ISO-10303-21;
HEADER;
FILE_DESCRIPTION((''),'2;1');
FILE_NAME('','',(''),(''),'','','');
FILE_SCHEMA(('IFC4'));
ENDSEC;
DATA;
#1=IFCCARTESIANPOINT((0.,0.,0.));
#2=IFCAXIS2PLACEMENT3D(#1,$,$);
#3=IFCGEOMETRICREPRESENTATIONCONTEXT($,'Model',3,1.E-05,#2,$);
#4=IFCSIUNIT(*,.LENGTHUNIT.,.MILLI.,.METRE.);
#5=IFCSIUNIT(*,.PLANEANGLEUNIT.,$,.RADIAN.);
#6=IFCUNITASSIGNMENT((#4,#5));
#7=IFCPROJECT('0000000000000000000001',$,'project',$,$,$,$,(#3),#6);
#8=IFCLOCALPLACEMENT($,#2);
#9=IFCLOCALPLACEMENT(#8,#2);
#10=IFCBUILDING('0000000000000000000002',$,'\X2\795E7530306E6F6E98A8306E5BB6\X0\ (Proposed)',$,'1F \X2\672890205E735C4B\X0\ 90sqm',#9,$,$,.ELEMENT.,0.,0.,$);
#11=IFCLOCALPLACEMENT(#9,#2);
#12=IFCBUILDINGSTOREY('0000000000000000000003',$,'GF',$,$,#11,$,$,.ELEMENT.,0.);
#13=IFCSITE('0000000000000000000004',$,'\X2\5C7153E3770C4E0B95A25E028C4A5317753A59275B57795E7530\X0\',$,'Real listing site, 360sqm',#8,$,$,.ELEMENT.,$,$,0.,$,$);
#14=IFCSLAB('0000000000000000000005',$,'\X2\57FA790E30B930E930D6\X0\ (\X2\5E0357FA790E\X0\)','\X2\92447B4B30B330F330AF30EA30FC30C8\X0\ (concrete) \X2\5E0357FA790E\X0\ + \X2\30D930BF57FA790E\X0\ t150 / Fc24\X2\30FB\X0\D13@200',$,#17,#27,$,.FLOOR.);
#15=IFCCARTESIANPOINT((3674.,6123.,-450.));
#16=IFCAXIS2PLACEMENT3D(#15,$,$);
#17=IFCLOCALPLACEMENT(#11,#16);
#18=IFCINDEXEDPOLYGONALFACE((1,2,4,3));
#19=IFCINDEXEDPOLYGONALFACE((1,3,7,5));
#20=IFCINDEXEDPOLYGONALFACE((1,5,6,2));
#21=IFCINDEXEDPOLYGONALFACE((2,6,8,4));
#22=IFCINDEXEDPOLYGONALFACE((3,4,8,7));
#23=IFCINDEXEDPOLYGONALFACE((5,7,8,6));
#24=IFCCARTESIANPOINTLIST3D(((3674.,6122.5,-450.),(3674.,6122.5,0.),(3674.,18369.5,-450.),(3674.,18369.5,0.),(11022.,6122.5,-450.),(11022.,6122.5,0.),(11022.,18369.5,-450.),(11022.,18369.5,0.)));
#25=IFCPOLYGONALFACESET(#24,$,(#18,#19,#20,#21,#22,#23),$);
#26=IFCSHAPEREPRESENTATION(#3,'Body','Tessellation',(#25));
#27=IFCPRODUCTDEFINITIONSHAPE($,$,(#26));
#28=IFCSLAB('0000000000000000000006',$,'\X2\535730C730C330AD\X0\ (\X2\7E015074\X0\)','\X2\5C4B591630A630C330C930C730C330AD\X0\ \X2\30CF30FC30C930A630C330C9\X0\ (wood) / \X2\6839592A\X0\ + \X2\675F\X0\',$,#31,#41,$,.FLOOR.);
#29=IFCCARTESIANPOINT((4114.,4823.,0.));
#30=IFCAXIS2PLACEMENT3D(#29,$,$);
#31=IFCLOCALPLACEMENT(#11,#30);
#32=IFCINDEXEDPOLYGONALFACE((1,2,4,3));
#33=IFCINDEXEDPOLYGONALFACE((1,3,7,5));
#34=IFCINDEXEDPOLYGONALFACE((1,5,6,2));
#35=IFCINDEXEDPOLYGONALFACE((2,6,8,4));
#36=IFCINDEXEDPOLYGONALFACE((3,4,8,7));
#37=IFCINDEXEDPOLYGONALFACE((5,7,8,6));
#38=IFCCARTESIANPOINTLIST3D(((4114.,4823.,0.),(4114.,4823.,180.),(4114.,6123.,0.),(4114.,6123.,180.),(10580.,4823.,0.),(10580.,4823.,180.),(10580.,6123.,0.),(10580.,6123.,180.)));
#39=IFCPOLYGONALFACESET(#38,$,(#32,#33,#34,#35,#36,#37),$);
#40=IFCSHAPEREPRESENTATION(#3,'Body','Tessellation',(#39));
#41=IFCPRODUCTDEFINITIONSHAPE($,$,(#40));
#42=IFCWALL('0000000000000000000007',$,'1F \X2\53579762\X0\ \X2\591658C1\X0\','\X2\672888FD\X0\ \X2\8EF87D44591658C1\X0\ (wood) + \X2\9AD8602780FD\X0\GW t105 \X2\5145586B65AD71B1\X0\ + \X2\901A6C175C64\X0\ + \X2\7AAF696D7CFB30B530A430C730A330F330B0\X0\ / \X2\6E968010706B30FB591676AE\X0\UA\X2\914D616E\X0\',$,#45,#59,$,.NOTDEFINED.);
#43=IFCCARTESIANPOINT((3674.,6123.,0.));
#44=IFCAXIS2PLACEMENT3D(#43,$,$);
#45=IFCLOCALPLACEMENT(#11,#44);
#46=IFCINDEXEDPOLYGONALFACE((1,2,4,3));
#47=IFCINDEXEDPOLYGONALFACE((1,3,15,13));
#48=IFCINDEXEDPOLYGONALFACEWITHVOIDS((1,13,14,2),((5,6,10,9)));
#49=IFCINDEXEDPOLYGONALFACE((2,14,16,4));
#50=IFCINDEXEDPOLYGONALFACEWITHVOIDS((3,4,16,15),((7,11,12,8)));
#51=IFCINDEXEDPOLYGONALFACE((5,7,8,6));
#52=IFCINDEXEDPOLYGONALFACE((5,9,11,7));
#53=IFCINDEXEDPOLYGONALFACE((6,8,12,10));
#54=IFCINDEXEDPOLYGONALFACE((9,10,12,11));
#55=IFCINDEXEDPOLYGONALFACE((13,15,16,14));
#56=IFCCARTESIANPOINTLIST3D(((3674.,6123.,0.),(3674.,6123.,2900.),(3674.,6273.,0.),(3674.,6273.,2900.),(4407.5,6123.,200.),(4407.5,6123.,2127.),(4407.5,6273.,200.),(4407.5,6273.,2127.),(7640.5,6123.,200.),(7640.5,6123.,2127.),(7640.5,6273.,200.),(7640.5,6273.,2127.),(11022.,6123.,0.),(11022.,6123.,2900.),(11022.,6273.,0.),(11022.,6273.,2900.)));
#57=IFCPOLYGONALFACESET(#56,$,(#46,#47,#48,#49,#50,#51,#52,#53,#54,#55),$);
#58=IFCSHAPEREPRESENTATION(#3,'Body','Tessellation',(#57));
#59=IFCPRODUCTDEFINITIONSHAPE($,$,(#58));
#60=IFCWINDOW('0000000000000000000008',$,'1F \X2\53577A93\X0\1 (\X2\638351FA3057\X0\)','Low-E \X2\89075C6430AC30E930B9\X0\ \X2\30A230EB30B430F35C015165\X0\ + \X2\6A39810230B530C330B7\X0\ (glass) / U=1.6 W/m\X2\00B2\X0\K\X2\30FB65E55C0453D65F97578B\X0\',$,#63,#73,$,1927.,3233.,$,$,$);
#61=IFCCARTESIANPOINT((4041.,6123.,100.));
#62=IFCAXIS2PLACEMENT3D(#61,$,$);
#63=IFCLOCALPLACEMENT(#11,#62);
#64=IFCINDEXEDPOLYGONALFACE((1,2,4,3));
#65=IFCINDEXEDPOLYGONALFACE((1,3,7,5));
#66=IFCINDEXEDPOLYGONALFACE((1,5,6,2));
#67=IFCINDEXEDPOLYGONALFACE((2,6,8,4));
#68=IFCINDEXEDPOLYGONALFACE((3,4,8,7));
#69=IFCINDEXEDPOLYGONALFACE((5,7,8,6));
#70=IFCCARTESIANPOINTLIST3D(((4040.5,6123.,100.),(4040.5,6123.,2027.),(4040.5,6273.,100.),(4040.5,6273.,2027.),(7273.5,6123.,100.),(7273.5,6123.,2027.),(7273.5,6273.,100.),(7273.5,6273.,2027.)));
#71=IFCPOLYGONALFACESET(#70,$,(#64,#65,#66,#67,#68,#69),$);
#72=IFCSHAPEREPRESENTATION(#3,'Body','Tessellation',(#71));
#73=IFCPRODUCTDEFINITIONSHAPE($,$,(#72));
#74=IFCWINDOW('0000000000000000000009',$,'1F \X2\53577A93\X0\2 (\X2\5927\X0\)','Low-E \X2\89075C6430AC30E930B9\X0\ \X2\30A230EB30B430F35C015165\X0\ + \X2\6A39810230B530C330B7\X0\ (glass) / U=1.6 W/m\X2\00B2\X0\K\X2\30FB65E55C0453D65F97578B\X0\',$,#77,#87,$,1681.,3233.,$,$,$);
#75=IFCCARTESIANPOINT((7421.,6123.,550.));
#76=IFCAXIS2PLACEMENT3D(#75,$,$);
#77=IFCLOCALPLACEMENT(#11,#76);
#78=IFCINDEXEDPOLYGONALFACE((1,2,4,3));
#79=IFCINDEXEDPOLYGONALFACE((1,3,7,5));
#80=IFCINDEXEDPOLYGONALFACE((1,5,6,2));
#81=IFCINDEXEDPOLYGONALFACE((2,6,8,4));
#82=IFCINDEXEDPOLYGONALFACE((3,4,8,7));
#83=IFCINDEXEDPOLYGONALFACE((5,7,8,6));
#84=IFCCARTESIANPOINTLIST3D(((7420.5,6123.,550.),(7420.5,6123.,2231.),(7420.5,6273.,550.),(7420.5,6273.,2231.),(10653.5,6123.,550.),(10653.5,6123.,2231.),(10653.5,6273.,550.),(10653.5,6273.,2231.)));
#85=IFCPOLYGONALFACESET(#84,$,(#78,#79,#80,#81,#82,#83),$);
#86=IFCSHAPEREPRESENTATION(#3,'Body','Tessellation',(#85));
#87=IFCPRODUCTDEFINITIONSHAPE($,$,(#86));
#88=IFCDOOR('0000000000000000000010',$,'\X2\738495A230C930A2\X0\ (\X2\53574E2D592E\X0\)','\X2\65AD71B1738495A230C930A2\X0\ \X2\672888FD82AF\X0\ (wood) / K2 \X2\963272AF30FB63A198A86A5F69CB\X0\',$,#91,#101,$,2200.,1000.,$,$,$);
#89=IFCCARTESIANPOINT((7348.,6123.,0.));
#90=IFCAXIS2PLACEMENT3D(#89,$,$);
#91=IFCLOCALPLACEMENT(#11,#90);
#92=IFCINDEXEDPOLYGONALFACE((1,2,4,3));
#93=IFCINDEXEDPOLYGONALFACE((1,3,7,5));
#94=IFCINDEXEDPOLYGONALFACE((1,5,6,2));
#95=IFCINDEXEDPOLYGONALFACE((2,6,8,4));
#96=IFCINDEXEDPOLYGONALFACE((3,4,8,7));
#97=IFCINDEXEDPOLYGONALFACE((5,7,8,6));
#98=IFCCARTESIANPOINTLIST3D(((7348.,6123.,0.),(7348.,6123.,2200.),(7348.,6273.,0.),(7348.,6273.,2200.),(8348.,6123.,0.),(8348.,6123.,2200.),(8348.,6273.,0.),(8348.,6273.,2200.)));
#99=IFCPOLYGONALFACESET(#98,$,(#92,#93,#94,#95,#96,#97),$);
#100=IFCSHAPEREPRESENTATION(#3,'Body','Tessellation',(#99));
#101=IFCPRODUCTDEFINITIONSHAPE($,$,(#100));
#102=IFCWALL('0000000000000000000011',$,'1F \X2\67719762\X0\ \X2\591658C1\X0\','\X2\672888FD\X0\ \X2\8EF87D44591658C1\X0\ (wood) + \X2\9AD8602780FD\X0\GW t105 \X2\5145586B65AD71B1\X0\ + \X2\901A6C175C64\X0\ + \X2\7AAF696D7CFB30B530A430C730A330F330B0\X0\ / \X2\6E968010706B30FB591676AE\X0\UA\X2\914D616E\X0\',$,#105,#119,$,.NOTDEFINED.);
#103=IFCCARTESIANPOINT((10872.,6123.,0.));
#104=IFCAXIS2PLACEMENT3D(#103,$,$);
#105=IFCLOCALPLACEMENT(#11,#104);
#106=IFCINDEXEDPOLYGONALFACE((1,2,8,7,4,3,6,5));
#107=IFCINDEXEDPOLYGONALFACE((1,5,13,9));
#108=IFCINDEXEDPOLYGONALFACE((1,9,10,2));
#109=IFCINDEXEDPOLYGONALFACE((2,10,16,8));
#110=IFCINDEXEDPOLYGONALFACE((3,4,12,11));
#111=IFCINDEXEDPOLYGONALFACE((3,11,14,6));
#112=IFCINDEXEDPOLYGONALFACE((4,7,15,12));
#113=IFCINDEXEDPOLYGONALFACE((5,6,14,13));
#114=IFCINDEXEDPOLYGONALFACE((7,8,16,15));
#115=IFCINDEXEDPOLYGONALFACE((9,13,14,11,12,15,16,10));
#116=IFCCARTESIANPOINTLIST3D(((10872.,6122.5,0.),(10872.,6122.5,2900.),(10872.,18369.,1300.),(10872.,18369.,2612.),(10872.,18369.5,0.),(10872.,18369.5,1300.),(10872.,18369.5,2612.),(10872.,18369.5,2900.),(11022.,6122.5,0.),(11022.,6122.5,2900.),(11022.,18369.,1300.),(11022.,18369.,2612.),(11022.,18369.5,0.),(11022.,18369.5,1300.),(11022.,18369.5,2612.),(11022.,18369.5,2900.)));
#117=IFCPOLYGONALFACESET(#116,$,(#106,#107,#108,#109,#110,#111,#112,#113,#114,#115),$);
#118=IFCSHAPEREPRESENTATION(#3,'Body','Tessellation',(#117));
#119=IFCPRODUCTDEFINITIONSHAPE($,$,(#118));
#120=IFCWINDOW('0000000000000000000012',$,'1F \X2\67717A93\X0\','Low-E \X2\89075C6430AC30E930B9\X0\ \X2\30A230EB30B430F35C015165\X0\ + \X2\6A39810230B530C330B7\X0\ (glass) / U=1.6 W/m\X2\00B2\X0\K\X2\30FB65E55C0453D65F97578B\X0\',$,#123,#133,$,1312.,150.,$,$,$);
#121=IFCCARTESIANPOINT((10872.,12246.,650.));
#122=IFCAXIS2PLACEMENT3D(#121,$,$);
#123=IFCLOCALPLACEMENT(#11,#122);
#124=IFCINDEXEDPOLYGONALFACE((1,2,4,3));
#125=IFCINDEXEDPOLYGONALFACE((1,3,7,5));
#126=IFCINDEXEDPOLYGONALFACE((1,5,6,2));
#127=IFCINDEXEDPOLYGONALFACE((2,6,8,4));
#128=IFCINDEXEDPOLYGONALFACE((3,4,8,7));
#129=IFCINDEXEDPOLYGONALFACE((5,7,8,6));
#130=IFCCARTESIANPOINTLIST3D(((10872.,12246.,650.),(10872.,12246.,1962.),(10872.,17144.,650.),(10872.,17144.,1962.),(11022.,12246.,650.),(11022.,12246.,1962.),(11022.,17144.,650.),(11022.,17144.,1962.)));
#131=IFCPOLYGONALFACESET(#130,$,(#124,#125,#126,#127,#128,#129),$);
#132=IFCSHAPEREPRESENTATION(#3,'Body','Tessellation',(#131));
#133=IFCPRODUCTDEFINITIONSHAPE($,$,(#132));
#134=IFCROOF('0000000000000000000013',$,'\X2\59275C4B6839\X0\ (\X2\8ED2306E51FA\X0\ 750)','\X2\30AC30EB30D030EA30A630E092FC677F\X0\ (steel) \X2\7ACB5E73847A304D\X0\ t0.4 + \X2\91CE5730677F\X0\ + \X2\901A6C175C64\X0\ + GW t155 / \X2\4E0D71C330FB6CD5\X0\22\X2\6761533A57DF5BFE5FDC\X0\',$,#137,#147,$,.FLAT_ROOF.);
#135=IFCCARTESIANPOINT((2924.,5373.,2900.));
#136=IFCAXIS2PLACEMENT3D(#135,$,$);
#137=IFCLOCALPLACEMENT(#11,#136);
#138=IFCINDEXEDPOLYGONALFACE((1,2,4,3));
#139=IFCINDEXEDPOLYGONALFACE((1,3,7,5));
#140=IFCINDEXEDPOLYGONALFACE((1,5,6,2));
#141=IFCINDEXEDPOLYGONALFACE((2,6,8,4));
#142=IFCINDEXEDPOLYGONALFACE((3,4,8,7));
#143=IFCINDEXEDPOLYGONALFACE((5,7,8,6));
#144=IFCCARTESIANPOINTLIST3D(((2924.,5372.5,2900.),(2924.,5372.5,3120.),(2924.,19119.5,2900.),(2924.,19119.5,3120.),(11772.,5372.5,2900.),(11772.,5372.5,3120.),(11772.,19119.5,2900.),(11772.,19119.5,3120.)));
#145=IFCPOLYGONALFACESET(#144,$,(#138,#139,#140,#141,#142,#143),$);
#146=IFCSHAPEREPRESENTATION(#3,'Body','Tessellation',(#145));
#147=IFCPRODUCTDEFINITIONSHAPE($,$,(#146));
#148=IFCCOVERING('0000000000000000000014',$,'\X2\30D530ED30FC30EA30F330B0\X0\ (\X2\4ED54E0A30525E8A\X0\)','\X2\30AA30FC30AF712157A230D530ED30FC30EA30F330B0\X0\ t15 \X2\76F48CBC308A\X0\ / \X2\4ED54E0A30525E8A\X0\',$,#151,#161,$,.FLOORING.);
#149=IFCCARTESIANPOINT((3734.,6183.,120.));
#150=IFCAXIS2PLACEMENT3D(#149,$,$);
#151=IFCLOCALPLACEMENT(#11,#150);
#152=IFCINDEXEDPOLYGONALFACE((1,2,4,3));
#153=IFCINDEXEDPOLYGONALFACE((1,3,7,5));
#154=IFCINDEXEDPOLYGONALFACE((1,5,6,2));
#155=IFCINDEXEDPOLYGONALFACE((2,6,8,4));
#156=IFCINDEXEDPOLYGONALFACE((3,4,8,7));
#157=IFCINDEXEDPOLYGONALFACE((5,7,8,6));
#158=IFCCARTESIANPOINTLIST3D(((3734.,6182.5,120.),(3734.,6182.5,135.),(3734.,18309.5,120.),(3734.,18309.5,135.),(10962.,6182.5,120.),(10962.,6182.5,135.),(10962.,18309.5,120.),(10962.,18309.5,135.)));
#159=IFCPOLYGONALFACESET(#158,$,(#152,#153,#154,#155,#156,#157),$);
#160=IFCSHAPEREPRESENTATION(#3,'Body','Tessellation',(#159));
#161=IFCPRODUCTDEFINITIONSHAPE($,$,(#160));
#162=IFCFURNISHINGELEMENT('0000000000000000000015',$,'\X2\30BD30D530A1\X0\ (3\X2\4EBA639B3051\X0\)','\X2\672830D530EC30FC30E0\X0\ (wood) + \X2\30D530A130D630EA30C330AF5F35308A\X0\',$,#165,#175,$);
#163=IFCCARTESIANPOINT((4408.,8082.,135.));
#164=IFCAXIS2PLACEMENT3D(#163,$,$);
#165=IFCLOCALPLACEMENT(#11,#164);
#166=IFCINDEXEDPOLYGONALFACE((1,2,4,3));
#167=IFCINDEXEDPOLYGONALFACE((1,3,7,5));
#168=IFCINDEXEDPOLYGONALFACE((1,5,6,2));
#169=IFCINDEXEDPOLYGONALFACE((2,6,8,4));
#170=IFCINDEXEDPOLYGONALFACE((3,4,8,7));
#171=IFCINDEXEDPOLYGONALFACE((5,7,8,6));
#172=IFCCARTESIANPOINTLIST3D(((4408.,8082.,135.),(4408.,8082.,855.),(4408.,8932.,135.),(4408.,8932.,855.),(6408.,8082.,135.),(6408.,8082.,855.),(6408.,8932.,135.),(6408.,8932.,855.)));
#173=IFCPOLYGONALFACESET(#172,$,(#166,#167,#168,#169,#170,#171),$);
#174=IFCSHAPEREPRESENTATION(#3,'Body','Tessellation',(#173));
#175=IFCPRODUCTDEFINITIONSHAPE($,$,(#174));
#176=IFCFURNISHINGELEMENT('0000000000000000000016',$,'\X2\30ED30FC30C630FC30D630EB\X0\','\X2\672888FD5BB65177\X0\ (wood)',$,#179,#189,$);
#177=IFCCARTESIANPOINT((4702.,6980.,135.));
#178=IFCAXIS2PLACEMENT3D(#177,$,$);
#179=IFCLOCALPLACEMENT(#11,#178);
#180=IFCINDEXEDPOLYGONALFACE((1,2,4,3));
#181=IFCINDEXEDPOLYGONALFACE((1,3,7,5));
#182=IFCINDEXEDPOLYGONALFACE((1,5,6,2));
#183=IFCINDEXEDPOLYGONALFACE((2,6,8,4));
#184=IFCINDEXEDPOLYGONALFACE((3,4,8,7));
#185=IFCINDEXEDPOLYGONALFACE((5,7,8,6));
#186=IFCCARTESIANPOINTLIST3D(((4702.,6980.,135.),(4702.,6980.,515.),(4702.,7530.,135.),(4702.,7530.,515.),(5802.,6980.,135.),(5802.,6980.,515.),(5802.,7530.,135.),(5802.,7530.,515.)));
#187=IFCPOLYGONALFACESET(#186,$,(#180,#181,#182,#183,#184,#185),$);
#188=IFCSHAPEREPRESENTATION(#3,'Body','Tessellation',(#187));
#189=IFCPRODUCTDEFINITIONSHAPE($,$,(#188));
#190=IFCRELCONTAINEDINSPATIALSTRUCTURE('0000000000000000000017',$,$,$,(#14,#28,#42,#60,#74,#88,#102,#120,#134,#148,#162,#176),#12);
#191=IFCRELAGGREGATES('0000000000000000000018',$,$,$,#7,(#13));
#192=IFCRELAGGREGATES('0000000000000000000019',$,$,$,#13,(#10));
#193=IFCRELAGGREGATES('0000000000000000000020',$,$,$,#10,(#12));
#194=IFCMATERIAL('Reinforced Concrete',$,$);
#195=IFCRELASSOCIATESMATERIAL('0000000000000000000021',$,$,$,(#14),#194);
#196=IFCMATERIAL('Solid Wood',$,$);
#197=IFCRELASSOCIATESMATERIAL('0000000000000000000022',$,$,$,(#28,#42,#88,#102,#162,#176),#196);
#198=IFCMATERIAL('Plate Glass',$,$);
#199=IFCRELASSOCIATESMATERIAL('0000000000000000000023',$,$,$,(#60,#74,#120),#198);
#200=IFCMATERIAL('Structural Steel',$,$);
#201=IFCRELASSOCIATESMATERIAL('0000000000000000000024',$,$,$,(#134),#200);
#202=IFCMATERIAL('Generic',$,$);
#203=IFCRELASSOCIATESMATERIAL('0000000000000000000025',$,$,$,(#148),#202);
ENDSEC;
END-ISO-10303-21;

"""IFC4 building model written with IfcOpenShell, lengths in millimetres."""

from ifc_helpers import new_model, si_unit, frame, frame_2d, origin, place, context, project, spatial, rectangle, extrude, material, element, fill, save


model = new_model("IFC4")

# Units and contexts
model_context = context("Model", 3, precision=1e-05, world=origin())
ifc_project = project(units=[si_unit("LENGTHUNIT", "METRE", prefix="MILLI"), si_unit("PLANEANGLEUNIT", "RADIAN")], contexts=[model_context])

# Site, building, storey
site_placement = place(None, origin())
site = spatial("IfcSite", under=ifc_project, at=site_placement, Name="山口県下関市豊北町大字神田", ObjectType="Real listing site, 360sqm", CompositionType="ELEMENT", RefElevation=0.0)
building_placement = place(site_placement, origin())
building = spatial("IfcBuilding", under=site, at=building_placement, Name="神田の潮風の家 (Proposed)", ObjectType="1F 木造平屋 90sqm", CompositionType="ELEMENT", ElevationOfRefHeight=0.0, ElevationOfTerrain=0.0)
storey_placement = place(building_placement, origin())
storey = spatial("IfcBuildingStorey", under=building, at=storey_placement, Name="GF", CompositionType="ELEMENT", Elevation=0.0)

# Slabs
ifc_material_1 = material(Name="Reinforced Concrete")
slab_1_placement = place(storey_placement, frame((3674.0, 6123.0, -450.0)))
element("IfcSlab", 1, at=slab_1_placement, inside=storey, material=ifc_material_1, Name="基礎スラブ (布基礎)", Description="鉄筋コンクリート (concrete) 布基礎 + ベタ基礎 t150 / Fc24・D13@200", PredefinedType="FLOOR", context=model_context, shape_type="SweptSolid", body=[
    extrude(rectangle(XDim=7348.0, YDim=12247.0, at=frame_2d((3674.0, 6123.0))), frame((3674.0, 6123.0, -450.0)), (0.0, 0.0, 1.0), 450.0),
])
ifc_material_2 = material(Name="Solid Wood")
slab_2_placement = place(storey_placement, frame((4114.0, 4823.0, 0.0)))
element("IfcSlab", 2, at=slab_2_placement, inside=storey, material=ifc_material_2, Name="南デッキ (縁側)", Description="屋外ウッドデッキ ハードウッド (wood) / 根太 + 束", PredefinedType="FLOOR", context=model_context, shape_type="SweptSolid", body=[
    extrude(rectangle(XDim=6466.0, YDim=1300.0, at=frame_2d((3233.0, 650.0))), frame((4114.0, 4823.0, 0.0)), (0.0, 0.0, 1.0), 180.0),
])

# Wall, openings, windows, door
wall_1_placement = place(storey_placement, frame((3674.0, 6123.0, 0.0)))
wall_1 = element("IfcWall", 3, at=wall_1_placement, inside=storey, material=ifc_material_2, Name="1F 南面 外壁", Description="木製 軸組外壁 (wood) + 高性能GW t105 充填断熱 + 通気層 + 窯業系サイディング / 準耐火・外皮UA配慮", PredefinedType="NOTDEFINED", context=model_context, shape_type="SweptSolid", body=[
    extrude(rectangle(XDim=7348.0, YDim=150.0, at=frame_2d((3674.0, 75.0))), frame((3674.0, 6123.0, 0.0)), (0.0, 0.0, 1.0), 2900.0),
])
opening_1_placement = place(storey_placement, frame((4041.0, 6123.0, 100.0)))
opening_1 = element("IfcOpeningElement", 4, at=opening_1_placement, cuts=wall_1, PredefinedType="NOTDEFINED", context=model_context, shape_type="SweptSolid", body=[
    extrude(rectangle(XDim=3233.0, YDim=150.0, at=frame_2d((1616.0, 75.0))), frame((4041.0, 6123.0, 100.0)), (0.0, 0.0, 1.0), 1927.0),
])
opening_2_placement = place(storey_placement, frame((7421.0, 6123.0, 550.0)))
opening_2 = element("IfcOpeningElement", 5, at=opening_2_placement, cuts=wall_1, PredefinedType="NOTDEFINED", context=model_context, shape_type="SweptSolid", body=[
    extrude(rectangle(XDim=3233.0, YDim=150.0, at=frame_2d((1616.0, 75.0))), frame((7421.0, 6123.0, 550.0)), (0.0, 0.0, 1.0), 1681.0),
])
opening_3_placement = place(storey_placement, frame((7348.0, 6123.0, 0.0)))
opening_3 = element("IfcOpeningElement", 6, at=opening_3_placement, cuts=wall_1, PredefinedType="NOTDEFINED", context=model_context, shape_type="SweptSolid", body=[
    extrude(rectangle(XDim=1000.0, YDim=150.0, at=frame_2d((500.0, 75.0))), frame((7348.0, 6123.0, 0.0)), (0.0, 0.0, 1.0), 2200.0),
])
ifc_material_3 = material(Name="Plate Glass")
window_1_placement = place(storey_placement, frame((4041.0, 6123.0, 100.0)))
window_1 = element("IfcWindow", 7, at=window_1_placement, inside=storey, material=ifc_material_3, Name="1F 南窓1 (掃出し)", Description="Low-E 複層ガラス アルゴン封入 + 樹脂サッシ (glass) / U=1.6 W/m²K・日射取得型", OverallHeight=1927.0, OverallWidth=3233.0, context=model_context, shape_type="SweptSolid", body=[
    extrude(rectangle(XDim=3233.0, YDim=150.0, at=frame_2d((1616.0, 75.0))), frame((4041.0, 6123.0, 100.0)), (0.0, 0.0, 1.0), 1927.0),
])
fill(opening_1, window_1)
window_2_placement = place(storey_placement, frame((7421.0, 6123.0, 550.0)))
window_2 = element("IfcWindow", 8, at=window_2_placement, inside=storey, material=ifc_material_3, Name="1F 南窓2 (大)", Description="Low-E 複層ガラス アルゴン封入 + 樹脂サッシ (glass) / U=1.6 W/m²K・日射取得型", OverallHeight=1681.0, OverallWidth=3233.0, context=model_context, shape_type="SweptSolid", body=[
    extrude(rectangle(XDim=3233.0, YDim=150.0, at=frame_2d((1616.0, 75.0))), frame((7421.0, 6123.0, 550.0)), (0.0, 0.0, 1.0), 1681.0),
])
fill(opening_2, window_2)
door_placement = place(storey_placement, frame((7348.0, 6123.0, 0.0)))
door = element("IfcDoor", 9, at=door_placement, inside=storey, material=ifc_material_2, Name="玄関ドア (南中央)", Description="断熱玄関ドア 木製芯 (wood) / K2 防犯・採風機構", OverallHeight=2200.0, OverallWidth=1000.0, context=model_context, shape_type="SweptSolid", body=[
    extrude(rectangle(XDim=1000.0, YDim=150.0, at=frame_2d((500.0, 75.0))), frame((7348.0, 6123.0, 0.0)), (0.0, 0.0, 1.0), 2200.0),
])
fill(opening_3, door)

# Wall, opening, window
wall_2_placement = place(storey_placement, frame((10872.0, 6123.0, 0.0)))
wall_2 = element("IfcWall", 10, at=wall_2_placement, inside=storey, material=ifc_material_2, Name="1F 東面 外壁", Description="木製 軸組外壁 (wood) + 高性能GW t105 充填断熱 + 通気層 + 窯業系サイディング / 準耐火・外皮UA配慮", PredefinedType="NOTDEFINED", context=model_context, shape_type="SweptSolid", body=[
    extrude(rectangle(XDim=150.0, YDim=12247.0, at=frame_2d((75.0, 6123.0))), frame((10872.0, 6123.0, 0.0)), (0.0, 0.0, 1.0), 2900.0),
])
opening_4_placement = place(storey_placement, frame((10872.0, 12246.0, 650.0)))
opening_4 = element("IfcOpeningElement", 11, at=opening_4_placement, cuts=wall_2, PredefinedType="NOTDEFINED", context=model_context, shape_type="SweptSolid", body=[
    extrude(rectangle(XDim=150.0, YDim=4898.0, at=frame_2d((75.0, 2449.0))), frame((10872.0, 12246.0, 650.0)), (0.0, 0.0, 1.0), 1312.0),
])
window_3_placement = place(storey_placement, frame((10872.0, 12246.0, 650.0)))
window_3 = element("IfcWindow", 12, at=window_3_placement, inside=storey, material=ifc_material_3, Name="1F 東窓", Description="Low-E 複層ガラス アルゴン封入 + 樹脂サッシ (glass) / U=1.6 W/m²K・日射取得型", OverallHeight=1312.0, OverallWidth=150.0, context=model_context, shape_type="SweptSolid", body=[
    extrude(rectangle(XDim=150.0, YDim=4898.0, at=frame_2d((75.0, 2449.0))), frame((10872.0, 12246.0, 650.0)), (0.0, 0.0, 1.0), 1312.0),
])
fill(opening_4, window_3)

# Roof
ifc_material_4 = material(Name="Structural Steel")
roof_placement = place(storey_placement, frame((2924.0, 5373.0, 2900.0)))
element("IfcRoof", 13, at=roof_placement, inside=storey, material=ifc_material_4, Name="大屋根 (軒の出 750)", Description="ガルバリウム鋼板 (steel) 立平葺き t0.4 + 野地板 + 通気層 + GW t155 / 不燃・法22条区域対応", PredefinedType="FLAT_ROOF", context=model_context, shape_type="SweptSolid", body=[
    extrude(rectangle(XDim=8848.0, YDim=13747.0, at=frame_2d((4424.0, 6873.0))), frame((2924.0, 5373.0, 2900.0)), (0.0, 0.0, 1.0), 220.0),
])

# Covering
ifc_material_5 = material(Name="Generic")
covering_placement = place(storey_placement, frame((3734.0, 6183.0, 120.0)))
element("IfcCovering", 14, at=covering_placement, inside=storey, material=ifc_material_5, Name="フローリング (仕上げ床)", Description="オーク無垢フローリング t15 直貼り / 仕上げ床", PredefinedType="FLOORING", context=model_context, shape_type="SweptSolid", body=[
    extrude(rectangle(XDim=7228.0, YDim=12127.0, at=frame_2d((3614.0, 6063.0))), frame((3734.0, 6183.0, 120.0)), (0.0, 0.0, 1.0), 15.0),
])

# Furnishing elements
furnishing_1_placement = place(storey_placement, frame((4408.0, 8082.0, 135.0)))
element("IfcFurnishingElement", 15, at=furnishing_1_placement, inside=storey, material=ifc_material_2, Name="ソファ (3人掛け)", Description="木フレーム (wood) + ファブリック張り", context=model_context, shape_type="SweptSolid", body=[
    extrude(rectangle(XDim=2000.0, YDim=850.0, at=frame_2d((1000.0, 425.0))), frame((4408.0, 8082.0, 135.0)), (0.0, 0.0, 1.0), 720.0),
])
furnishing_2_placement = place(storey_placement, frame((4702.0, 6980.0, 135.0)))
element("IfcFurnishingElement", 16, at=furnishing_2_placement, inside=storey, material=ifc_material_2, Name="ローテーブル", Description="木製家具 (wood)", context=model_context, shape_type="SweptSolid", body=[
    extrude(rectangle(XDim=1100.0, YDim=550.0, at=frame_2d((550.0, 275.0))), frame((4702.0, 6980.0, 135.0)), (0.0, 0.0, 1.0), 380.0),
])

save(model, "model.ifc")
